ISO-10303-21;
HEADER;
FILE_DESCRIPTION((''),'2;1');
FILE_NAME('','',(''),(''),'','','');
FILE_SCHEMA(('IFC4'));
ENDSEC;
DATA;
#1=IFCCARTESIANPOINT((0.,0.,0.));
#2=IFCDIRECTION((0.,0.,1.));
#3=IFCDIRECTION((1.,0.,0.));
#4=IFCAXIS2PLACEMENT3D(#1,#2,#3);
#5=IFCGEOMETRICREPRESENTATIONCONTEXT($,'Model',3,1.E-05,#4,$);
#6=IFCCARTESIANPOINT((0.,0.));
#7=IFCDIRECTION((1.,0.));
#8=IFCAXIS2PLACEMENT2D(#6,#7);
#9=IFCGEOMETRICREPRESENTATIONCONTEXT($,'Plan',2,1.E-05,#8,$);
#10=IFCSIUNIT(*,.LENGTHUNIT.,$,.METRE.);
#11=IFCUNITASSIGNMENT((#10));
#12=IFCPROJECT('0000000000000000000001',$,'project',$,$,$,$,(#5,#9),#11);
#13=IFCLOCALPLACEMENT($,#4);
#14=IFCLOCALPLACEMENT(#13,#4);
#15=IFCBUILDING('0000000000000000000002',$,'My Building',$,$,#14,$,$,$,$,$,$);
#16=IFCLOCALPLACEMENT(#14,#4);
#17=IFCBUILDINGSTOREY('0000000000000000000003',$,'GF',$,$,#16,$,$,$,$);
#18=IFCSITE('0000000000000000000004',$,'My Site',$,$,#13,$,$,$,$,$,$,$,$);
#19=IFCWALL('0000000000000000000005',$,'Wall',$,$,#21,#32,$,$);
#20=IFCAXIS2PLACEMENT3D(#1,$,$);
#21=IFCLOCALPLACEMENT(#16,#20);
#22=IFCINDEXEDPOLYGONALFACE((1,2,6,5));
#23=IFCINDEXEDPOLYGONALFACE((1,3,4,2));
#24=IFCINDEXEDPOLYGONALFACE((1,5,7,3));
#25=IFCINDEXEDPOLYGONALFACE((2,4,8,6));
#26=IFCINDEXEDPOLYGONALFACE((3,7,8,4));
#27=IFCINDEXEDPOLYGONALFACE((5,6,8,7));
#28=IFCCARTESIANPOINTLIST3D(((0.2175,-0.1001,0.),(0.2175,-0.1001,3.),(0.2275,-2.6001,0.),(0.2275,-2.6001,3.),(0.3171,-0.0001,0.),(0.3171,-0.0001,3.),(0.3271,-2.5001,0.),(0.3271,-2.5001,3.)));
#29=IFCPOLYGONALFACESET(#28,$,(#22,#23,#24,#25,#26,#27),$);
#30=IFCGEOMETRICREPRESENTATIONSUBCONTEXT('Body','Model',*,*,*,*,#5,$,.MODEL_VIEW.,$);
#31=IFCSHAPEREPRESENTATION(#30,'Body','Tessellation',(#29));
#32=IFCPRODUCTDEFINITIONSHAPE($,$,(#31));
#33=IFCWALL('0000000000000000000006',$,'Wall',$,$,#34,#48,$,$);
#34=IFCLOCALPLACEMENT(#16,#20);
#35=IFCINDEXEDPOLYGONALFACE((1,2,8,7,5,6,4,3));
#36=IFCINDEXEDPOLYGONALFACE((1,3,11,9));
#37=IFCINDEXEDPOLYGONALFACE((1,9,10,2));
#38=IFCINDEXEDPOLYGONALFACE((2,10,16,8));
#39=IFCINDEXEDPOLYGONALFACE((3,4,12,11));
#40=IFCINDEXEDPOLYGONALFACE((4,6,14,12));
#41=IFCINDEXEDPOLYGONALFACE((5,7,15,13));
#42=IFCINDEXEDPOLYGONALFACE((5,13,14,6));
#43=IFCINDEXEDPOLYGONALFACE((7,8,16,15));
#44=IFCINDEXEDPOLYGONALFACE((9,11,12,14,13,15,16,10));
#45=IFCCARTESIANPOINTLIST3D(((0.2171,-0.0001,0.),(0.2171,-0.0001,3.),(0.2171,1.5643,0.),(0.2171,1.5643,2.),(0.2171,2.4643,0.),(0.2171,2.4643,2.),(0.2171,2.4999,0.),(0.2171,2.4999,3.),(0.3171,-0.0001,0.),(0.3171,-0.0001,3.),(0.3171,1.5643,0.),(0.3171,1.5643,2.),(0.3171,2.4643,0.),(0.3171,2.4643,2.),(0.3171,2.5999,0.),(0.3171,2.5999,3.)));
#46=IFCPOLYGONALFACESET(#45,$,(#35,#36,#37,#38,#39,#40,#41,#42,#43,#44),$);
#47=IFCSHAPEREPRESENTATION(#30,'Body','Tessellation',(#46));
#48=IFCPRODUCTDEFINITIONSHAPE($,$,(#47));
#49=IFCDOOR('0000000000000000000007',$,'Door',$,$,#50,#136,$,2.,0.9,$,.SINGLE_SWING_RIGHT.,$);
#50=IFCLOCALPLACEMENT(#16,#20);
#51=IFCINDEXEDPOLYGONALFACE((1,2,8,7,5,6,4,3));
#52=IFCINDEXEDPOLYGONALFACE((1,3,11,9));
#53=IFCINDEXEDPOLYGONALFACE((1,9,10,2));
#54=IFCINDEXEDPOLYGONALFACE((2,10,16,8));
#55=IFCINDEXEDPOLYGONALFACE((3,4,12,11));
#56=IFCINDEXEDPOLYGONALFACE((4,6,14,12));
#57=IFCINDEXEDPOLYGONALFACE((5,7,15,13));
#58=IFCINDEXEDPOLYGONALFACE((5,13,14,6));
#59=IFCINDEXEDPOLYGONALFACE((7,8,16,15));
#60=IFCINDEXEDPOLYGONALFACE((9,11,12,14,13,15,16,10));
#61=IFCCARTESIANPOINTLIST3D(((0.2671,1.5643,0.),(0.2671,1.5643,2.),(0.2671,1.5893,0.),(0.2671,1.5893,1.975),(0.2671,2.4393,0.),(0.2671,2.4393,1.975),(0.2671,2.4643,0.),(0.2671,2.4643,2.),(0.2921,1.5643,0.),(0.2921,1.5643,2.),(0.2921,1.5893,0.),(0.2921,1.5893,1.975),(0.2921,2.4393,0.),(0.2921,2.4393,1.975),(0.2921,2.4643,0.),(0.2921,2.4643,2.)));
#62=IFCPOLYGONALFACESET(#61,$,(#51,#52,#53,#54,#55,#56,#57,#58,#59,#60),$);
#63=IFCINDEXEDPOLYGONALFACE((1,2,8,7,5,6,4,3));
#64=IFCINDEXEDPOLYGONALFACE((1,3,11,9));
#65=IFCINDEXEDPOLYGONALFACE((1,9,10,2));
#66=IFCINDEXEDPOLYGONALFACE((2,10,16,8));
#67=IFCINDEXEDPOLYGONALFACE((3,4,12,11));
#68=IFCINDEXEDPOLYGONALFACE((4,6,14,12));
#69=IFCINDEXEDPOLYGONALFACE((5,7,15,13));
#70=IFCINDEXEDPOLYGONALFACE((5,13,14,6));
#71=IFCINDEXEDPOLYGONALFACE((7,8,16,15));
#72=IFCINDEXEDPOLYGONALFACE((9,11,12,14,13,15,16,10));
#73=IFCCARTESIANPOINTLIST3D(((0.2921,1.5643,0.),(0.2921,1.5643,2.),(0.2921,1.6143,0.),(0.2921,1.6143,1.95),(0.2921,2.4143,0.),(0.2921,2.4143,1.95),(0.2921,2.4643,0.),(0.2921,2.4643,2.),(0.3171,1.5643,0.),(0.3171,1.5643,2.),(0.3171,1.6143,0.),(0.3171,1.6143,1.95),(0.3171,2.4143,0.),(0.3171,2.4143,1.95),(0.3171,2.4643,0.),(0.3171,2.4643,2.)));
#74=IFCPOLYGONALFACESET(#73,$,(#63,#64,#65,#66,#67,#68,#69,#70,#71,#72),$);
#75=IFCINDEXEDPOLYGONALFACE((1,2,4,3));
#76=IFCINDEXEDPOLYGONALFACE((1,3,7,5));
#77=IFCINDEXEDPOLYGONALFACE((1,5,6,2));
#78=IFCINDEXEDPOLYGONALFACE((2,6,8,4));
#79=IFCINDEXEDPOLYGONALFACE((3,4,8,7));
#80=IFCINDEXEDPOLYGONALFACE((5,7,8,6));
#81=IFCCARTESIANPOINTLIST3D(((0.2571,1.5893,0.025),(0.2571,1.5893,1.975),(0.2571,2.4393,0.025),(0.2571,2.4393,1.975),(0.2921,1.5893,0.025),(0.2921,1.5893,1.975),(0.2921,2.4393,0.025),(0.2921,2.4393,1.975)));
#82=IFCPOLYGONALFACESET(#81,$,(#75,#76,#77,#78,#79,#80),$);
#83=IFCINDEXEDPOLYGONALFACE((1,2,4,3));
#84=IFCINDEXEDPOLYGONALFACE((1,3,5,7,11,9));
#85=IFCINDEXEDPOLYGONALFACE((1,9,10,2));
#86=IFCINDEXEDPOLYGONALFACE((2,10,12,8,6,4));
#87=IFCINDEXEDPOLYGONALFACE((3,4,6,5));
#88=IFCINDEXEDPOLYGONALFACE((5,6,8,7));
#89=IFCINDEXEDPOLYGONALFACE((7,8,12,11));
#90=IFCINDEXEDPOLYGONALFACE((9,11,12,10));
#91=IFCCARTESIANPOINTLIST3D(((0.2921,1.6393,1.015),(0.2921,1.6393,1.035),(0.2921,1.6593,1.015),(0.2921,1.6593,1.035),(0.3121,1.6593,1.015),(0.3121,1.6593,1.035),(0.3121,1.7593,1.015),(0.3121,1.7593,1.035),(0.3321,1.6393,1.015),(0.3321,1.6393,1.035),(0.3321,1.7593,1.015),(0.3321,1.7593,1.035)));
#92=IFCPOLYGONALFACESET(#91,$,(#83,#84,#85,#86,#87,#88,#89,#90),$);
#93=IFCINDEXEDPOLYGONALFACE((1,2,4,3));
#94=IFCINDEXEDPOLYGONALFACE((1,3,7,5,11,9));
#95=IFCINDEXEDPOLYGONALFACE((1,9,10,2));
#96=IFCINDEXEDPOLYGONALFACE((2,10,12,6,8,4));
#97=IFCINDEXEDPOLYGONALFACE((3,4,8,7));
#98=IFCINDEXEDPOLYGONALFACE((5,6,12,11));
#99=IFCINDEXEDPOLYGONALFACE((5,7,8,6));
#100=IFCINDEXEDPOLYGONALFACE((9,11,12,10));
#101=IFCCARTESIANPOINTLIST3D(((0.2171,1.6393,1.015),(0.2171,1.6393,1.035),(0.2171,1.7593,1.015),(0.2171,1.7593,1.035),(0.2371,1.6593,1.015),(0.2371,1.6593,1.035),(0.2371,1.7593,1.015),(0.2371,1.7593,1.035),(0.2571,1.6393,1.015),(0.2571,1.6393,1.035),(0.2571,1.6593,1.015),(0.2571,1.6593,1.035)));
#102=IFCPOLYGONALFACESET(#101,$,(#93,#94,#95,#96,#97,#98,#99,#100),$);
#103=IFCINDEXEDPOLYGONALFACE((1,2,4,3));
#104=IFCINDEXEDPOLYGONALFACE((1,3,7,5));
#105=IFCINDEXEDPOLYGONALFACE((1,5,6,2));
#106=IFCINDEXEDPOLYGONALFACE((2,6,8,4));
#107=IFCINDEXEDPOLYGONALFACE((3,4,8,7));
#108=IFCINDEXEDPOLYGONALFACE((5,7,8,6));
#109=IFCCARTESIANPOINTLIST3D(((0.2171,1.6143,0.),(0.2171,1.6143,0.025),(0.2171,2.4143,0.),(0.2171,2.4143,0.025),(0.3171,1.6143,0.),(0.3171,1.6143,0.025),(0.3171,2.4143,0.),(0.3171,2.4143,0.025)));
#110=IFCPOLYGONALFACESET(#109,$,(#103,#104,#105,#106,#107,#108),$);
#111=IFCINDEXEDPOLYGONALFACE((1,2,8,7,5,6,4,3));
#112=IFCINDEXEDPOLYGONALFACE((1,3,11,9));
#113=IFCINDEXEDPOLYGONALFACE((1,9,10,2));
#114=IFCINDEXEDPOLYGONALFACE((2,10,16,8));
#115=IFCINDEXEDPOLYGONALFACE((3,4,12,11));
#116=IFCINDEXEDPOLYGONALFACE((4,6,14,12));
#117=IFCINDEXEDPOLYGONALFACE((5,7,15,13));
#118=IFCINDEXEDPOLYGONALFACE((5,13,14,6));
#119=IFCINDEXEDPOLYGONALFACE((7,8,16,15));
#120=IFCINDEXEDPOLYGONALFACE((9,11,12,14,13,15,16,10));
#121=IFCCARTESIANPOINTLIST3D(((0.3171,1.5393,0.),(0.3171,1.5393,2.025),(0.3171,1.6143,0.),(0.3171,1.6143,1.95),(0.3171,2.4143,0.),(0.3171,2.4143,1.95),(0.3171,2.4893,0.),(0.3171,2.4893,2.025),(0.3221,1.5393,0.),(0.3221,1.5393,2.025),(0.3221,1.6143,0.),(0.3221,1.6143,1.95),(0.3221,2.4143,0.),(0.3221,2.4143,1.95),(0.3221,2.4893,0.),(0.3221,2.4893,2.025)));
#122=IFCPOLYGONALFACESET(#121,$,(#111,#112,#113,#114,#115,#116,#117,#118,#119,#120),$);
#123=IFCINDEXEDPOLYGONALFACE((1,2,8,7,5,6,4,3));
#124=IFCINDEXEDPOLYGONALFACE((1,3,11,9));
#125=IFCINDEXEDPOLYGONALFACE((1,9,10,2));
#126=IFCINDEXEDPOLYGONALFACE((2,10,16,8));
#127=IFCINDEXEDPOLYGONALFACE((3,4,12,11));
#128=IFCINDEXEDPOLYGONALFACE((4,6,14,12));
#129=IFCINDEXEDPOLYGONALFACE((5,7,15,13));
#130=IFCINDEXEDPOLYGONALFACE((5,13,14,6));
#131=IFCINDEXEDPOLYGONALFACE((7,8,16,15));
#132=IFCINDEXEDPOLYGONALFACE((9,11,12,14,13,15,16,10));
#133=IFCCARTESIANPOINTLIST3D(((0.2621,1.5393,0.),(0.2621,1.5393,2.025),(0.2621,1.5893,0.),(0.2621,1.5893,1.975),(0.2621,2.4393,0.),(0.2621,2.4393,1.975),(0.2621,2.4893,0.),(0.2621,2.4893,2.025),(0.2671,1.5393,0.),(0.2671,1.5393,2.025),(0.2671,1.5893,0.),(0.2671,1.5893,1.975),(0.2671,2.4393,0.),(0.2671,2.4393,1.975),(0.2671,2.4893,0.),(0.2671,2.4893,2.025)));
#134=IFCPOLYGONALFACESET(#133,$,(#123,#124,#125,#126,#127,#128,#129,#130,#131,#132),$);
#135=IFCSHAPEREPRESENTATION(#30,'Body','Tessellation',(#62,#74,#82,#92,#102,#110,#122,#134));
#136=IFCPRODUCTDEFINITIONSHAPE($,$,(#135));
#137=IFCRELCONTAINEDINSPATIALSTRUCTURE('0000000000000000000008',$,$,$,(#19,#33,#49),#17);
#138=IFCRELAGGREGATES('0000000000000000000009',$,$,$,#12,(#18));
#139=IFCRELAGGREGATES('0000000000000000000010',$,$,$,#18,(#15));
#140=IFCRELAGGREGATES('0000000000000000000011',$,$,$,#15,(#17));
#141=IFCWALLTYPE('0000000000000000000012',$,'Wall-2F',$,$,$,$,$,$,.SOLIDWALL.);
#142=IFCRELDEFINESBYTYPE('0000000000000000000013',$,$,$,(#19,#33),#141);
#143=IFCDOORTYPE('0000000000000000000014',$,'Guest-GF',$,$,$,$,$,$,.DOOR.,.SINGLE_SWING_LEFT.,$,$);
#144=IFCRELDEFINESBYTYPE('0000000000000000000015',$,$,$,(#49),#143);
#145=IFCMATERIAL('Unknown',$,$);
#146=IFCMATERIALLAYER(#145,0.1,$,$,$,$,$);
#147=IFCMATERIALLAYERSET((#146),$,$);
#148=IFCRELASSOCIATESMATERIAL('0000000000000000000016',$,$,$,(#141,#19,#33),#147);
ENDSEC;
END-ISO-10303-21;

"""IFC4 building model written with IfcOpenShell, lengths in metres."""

from ifc_helpers import new_model, entity, si_unit, frame, origin_with_axes, origin_2d_with_axis, place, context, subcontext, project, spatial, line, indexed_curve, outline, extrude, shape, source, transform, mapped, material, layer, layer_set, layer_usage, type_object, type_shapes, element, fill, save


model = new_model("IFC4")

# Units and contexts
model_context = context("Model", 3, precision=1e-05, world=origin_with_axes())
plan_context = context("Plan", 2, precision=1e-05, world=origin_2d_with_axis())
body_context_1 = subcontext(model_context, "Body", "Model", "MODEL_VIEW")
body_context_2 = subcontext(plan_context, "Body", "Plan", "PLAN_VIEW")
ifc_project = project(units=[si_unit("LENGTHUNIT", "METRE")], contexts=[model_context, plan_context])

# Site, building, storey
site_placement = place(None, origin_with_axes())
site = spatial("IfcSite", under=ifc_project, at=site_placement, Name="My Site")
building_placement = place(site_placement, origin_with_axes())
building = spatial("IfcBuilding", under=site, at=building_placement, Name="My Building")
storey_placement = place(building_placement, origin_with_axes())
storey = spatial("IfcBuildingStorey", under=building, at=storey_placement, Name="GF")

# Shared definitions
ifc_material = material(Name="Unknown")

# Shared definitions
ifc_layer_1 = layer(ifc_material, 0.1)
ifc_layer_set_1 = layer_set([ifc_layer_1])
wall_type = type_object("IfcWallType", Name="Wall-2F", PredefinedType="SOLIDWALL", material=ifc_layer_set_1)

# Wall
ifc_layer_usage_1 = layer_usage(ifc_layer_set_1, "AXIS2", "POSITIVE", 0.0)
wall_1_placement = place(storey_placement, frame((0.2175, -0.1001, 0.0), z_axis=(0.0, 0.0, 1.0), x_axis=(0.004, -0.999992, 0.0)))
element("IfcWall", 1, at=wall_1_placement, inside=storey, type_object=wall_type, material=ifc_layer_usage_1, Name="Wall", context=body_context_1, shape_type="SweptSolid", body=[
    extrude(outline(indexed_curve([(0.0, 0.0), (-0.0996, 0.1), (2.4004, 0.1), (2.5, 0.0)], segments=[line(1, 2, 3, 4, 1)])), origin_with_axes(), (0.0, 0.0, 1.0), 3.0),
])

# Wall, opening, door
ifc_layer_usage_2 = layer_usage(ifc_layer_set_1, "AXIS2", "POSITIVE", 0.0)
wall_2_placement = place(storey_placement, frame((0.3171, -0.0001, 0.0), z_axis=(0.0, 0.0, 1.0), x_axis=(0.0, 1.0, 0.0)))
wall_2 = element("IfcWall", 2, at=wall_2_placement, inside=storey, type_object=wall_type, material=ifc_layer_usage_2, Name="Wall", context=body_context_1, shape_type="SweptSolid", body=[
    extrude(outline(indexed_curve([(0.0, 0.0), (0.0, 0.1), (2.5, 0.1), (2.6, 0.0)], segments=[line(1, 2, 3, 4, 1)])), origin_with_axes(), (0.0, 0.0, 1.0), 3.0),
])
shared_shape_1 = source(origin_with_axes(), body_context_1, "Body", "SweptSolid", [
    extrude(outline(indexed_curve([(0.0, 0.0), (0.9, 0.0), (0.9, 2.0), (0.0, 2.0)], segments=[line(1, 2, 3, 4, 1)])), frame((0.0, -0.6, 0.0), z_axis=(0.0, -1.0, 0.0), x_axis=(1.0, 0.0, 0.0)), (0.0, 0.0, -1.0), 1.2),
])
opening_1_placement = place(wall_2_placement, frame((1.5644, 0.0, 0.0), z_axis=(0.0, 0.0, 1.0), x_axis=(1.0, 0.0, 0.0)))
opening_1 = element("IfcOpeningElement", 3, at=opening_1_placement, cuts=wall_2, PredefinedType="OPENING", context=body_context_1, shape_type="MappedRepresentation", body=[
    mapped(shared_shape_1, transform((0.0, 0.0, 0.0), x_axis=(1.0, 0.0, 0.0), y_axis=(0.0, 1.0, 0.0), z_axis=(0.0, 0.0, 1.0), scale=1.0)),
])
door_type_1 = type_object("IfcDoorType", Name="Guest-GF", OperationType="SINGLE_SWING_LEFT", PredefinedType="DOOR")
shared_shape_2 = source(origin_with_axes(), body_context_1, "Body", "SweptSolid", [
    extrude(outline(indexed_curve([(0.0, 0.0), (0.0, 2.0), (0.9, 2.0), (0.9, 0.0), (0.875, 0.0), (0.875, 1.975), (0.025, 1.975), (0.025, 0.0)], segments=[line(1, 2, 3, 4, 5, 6, 7, 8, 1)])), frame((0.0, 0.025, 0.0), z_axis=(0.0, -1.0, 0.0), x_axis=(1.0, 0.0, 0.0)), (0.0, 0.0, -1.0), 0.025),
    extrude(outline(indexed_curve([(0.0, 0.0), (0.0, 2.0), (0.9, 2.0), (0.9, 0.0), (0.85, 0.0), (0.85, 1.95), (0.05, 1.95), (0.05, 0.0)], segments=[line(1, 2, 3, 4, 5, 6, 7, 8, 1)])), frame((0.0, 0.0, 0.0), z_axis=(0.0, -1.0, 0.0), x_axis=(1.0, 0.0, 0.0)), (0.0, 0.0, -1.0), 0.025),
    extrude(outline(indexed_curve([(0.0, 0.0), (0.85, 0.0), (0.85, 0.035), (0.0, 0.035)], segments=[line(1, 2, 3, 4, 1)])), frame((0.025, 0.025, 0.025), z_axis=(0.0, 0.0, 1.0), x_axis=(1.0, 0.0, 0.0)), (0.0, 0.0, 1.0), 1.95),
    extrude(outline(indexed_curve([(0.0, 0.0), (0.0, -0.04), (0.12, -0.04), (0.12, -0.02), (0.02, -0.02), (0.02, 0.0)], segments=[line(1, 2, 3, 4, 5, 6, 1)])), frame((0.075, 0.025, 1.015), z_axis=(0.0, 0.0, 1.0), x_axis=(1.0, 0.0, 0.0)), (0.0, 0.0, 1.0), 0.02),
    extrude(outline(indexed_curve([(0.0, 0.0), (0.0, 0.04), (0.12, 0.04), (0.12, 0.02), (0.02, 0.02), (0.02, 0.0)], segments=[line(1, 2, 3, 4, 5, 6, 1)])), frame((0.075, 0.06, 1.015), z_axis=(0.0, 0.0, 1.0), x_axis=(1.0, 0.0, 0.0)), (0.0, 0.0, 1.0), 0.02),
    extrude(outline(indexed_curve([(0.0, 0.0), (0.8, 0.0), (0.8, 0.1), (0.0, 0.1)], segments=[line(1, 2, 3, 4, 1)])), frame((0.05, 0.0, 0.0), z_axis=(0.0, 0.0, 1.0), x_axis=(1.0, 0.0, 0.0)), (0.0, 0.0, 1.0), 0.025),
    extrude(outline(indexed_curve([(0.0, 0.0), (0.0, 2.025), (0.95, 2.025), (0.95, 0.0), (0.875, 0.0), (0.875, 1.95), (0.075, 1.95), (0.075, 0.0)], segments=[line(1, 2, 3, 4, 5, 6, 7, 8, 1)])), frame((-0.025, -0.005, 0.0), z_axis=(0.0, -1.0, 0.0), x_axis=(1.0, 0.0, 0.0)), (0.0, 0.0, -1.0), 0.005),
    extrude(outline(indexed_curve([(0.0, 0.0), (0.0, 2.025), (0.95, 2.025), (0.95, 0.0), (0.9, 0.0), (0.9, 1.975), (0.05, 1.975), (0.05, 0.0)], segments=[line(1, 2, 3, 4, 5, 6, 7, 8, 1)])), frame((-0.025, 0.05, 0.0), z_axis=(0.0, -1.0, 0.0), x_axis=(1.0, 0.0, 0.0)), (0.0, 0.0, -1.0), 0.005),
])
shared_shape_3 = source(origin_with_axes(), body_context_2, "Body", "Curve2D", [
    entity("IfcIndexedPolyCurve", entity("IfcCartesianPointList2D", [[0.0, 0.0], [0.0, 0.05], [0.025, 0.05], [0.025, 0.025], [0.05, 0.025], [0.05, 0.0]]), [entity("IfcLineIndex", [1, 2, 3, 4, 5, 6, 1])]),
    entity("IfcIndexedPolyCurve", entity("IfcCartesianPointList2D", [[0.9, 0.0], [0.9, 0.05], [0.875, 0.05], [0.875, 0.025], [0.85, 0.025], [0.85, 0.0]]), [entity("IfcLineIndex", [1, 2, 3, 4, 5, 6, 1])]),
    entity("IfcTrimmedCurve", entity("IfcEllipse", entity("IfcAxis2Placement2D", entity("IfcCartesianPoint", [0.84, 0.05]), entity("IfcDirection", [1.0, 0.0])), 0.815, 0.85), [entity("IfcCartesianPoint", [0.84, 0.9])], [entity("IfcCartesianPoint", [0.025, 0.05])], True, "CARTESIAN"),
    entity("IfcIndexedPolyCurve", entity("IfcCartesianPointList2D", [[0.875, 0.05], [0.84, 0.05], [0.84, 0.9], [0.875, 0.9]]), [entity("IfcLineIndex", [1, 2, 3, 4, 1])]),
])
type_shapes(door_type_1, [shared_shape_2, shared_shape_3])
door_1_placement = place(opening_1_placement, frame((0.0, 0.0, 0.0), z_axis=(0.0, 0.0, 1.0), x_axis=(1.0, 0.0, 0.0)))
door_1 = element("IfcDoor", 4, at=door_1_placement, inside=storey, type_object=door_type_1, Name="Door", OperationType="SINGLE_SWING_RIGHT", OverallHeight=2.0, OverallWidth=0.9, shapes=[
    shape(body_context_1, "Body", "MappedRepresentation", [mapped(shared_shape_2, transform((0.0, 0.0, 0.0), x_axis=(1.0, 0.0, 0.0), y_axis=(0.0, 1.0, 0.0), z_axis=(0.0, 0.0, 1.0), scale=1.0))]),
    shape(body_context_2, "Body", "MappedRepresentation", [mapped(shared_shape_3, transform((0.0, 0.0, 0.0), x_axis=(1.0, 0.0, 0.0), y_axis=(0.0, 1.0, 0.0), z_axis=(0.0, 0.0, 1.0), scale=1.0))]),
])
fill(opening_1, door_1)

save(model, "model.ifc")
